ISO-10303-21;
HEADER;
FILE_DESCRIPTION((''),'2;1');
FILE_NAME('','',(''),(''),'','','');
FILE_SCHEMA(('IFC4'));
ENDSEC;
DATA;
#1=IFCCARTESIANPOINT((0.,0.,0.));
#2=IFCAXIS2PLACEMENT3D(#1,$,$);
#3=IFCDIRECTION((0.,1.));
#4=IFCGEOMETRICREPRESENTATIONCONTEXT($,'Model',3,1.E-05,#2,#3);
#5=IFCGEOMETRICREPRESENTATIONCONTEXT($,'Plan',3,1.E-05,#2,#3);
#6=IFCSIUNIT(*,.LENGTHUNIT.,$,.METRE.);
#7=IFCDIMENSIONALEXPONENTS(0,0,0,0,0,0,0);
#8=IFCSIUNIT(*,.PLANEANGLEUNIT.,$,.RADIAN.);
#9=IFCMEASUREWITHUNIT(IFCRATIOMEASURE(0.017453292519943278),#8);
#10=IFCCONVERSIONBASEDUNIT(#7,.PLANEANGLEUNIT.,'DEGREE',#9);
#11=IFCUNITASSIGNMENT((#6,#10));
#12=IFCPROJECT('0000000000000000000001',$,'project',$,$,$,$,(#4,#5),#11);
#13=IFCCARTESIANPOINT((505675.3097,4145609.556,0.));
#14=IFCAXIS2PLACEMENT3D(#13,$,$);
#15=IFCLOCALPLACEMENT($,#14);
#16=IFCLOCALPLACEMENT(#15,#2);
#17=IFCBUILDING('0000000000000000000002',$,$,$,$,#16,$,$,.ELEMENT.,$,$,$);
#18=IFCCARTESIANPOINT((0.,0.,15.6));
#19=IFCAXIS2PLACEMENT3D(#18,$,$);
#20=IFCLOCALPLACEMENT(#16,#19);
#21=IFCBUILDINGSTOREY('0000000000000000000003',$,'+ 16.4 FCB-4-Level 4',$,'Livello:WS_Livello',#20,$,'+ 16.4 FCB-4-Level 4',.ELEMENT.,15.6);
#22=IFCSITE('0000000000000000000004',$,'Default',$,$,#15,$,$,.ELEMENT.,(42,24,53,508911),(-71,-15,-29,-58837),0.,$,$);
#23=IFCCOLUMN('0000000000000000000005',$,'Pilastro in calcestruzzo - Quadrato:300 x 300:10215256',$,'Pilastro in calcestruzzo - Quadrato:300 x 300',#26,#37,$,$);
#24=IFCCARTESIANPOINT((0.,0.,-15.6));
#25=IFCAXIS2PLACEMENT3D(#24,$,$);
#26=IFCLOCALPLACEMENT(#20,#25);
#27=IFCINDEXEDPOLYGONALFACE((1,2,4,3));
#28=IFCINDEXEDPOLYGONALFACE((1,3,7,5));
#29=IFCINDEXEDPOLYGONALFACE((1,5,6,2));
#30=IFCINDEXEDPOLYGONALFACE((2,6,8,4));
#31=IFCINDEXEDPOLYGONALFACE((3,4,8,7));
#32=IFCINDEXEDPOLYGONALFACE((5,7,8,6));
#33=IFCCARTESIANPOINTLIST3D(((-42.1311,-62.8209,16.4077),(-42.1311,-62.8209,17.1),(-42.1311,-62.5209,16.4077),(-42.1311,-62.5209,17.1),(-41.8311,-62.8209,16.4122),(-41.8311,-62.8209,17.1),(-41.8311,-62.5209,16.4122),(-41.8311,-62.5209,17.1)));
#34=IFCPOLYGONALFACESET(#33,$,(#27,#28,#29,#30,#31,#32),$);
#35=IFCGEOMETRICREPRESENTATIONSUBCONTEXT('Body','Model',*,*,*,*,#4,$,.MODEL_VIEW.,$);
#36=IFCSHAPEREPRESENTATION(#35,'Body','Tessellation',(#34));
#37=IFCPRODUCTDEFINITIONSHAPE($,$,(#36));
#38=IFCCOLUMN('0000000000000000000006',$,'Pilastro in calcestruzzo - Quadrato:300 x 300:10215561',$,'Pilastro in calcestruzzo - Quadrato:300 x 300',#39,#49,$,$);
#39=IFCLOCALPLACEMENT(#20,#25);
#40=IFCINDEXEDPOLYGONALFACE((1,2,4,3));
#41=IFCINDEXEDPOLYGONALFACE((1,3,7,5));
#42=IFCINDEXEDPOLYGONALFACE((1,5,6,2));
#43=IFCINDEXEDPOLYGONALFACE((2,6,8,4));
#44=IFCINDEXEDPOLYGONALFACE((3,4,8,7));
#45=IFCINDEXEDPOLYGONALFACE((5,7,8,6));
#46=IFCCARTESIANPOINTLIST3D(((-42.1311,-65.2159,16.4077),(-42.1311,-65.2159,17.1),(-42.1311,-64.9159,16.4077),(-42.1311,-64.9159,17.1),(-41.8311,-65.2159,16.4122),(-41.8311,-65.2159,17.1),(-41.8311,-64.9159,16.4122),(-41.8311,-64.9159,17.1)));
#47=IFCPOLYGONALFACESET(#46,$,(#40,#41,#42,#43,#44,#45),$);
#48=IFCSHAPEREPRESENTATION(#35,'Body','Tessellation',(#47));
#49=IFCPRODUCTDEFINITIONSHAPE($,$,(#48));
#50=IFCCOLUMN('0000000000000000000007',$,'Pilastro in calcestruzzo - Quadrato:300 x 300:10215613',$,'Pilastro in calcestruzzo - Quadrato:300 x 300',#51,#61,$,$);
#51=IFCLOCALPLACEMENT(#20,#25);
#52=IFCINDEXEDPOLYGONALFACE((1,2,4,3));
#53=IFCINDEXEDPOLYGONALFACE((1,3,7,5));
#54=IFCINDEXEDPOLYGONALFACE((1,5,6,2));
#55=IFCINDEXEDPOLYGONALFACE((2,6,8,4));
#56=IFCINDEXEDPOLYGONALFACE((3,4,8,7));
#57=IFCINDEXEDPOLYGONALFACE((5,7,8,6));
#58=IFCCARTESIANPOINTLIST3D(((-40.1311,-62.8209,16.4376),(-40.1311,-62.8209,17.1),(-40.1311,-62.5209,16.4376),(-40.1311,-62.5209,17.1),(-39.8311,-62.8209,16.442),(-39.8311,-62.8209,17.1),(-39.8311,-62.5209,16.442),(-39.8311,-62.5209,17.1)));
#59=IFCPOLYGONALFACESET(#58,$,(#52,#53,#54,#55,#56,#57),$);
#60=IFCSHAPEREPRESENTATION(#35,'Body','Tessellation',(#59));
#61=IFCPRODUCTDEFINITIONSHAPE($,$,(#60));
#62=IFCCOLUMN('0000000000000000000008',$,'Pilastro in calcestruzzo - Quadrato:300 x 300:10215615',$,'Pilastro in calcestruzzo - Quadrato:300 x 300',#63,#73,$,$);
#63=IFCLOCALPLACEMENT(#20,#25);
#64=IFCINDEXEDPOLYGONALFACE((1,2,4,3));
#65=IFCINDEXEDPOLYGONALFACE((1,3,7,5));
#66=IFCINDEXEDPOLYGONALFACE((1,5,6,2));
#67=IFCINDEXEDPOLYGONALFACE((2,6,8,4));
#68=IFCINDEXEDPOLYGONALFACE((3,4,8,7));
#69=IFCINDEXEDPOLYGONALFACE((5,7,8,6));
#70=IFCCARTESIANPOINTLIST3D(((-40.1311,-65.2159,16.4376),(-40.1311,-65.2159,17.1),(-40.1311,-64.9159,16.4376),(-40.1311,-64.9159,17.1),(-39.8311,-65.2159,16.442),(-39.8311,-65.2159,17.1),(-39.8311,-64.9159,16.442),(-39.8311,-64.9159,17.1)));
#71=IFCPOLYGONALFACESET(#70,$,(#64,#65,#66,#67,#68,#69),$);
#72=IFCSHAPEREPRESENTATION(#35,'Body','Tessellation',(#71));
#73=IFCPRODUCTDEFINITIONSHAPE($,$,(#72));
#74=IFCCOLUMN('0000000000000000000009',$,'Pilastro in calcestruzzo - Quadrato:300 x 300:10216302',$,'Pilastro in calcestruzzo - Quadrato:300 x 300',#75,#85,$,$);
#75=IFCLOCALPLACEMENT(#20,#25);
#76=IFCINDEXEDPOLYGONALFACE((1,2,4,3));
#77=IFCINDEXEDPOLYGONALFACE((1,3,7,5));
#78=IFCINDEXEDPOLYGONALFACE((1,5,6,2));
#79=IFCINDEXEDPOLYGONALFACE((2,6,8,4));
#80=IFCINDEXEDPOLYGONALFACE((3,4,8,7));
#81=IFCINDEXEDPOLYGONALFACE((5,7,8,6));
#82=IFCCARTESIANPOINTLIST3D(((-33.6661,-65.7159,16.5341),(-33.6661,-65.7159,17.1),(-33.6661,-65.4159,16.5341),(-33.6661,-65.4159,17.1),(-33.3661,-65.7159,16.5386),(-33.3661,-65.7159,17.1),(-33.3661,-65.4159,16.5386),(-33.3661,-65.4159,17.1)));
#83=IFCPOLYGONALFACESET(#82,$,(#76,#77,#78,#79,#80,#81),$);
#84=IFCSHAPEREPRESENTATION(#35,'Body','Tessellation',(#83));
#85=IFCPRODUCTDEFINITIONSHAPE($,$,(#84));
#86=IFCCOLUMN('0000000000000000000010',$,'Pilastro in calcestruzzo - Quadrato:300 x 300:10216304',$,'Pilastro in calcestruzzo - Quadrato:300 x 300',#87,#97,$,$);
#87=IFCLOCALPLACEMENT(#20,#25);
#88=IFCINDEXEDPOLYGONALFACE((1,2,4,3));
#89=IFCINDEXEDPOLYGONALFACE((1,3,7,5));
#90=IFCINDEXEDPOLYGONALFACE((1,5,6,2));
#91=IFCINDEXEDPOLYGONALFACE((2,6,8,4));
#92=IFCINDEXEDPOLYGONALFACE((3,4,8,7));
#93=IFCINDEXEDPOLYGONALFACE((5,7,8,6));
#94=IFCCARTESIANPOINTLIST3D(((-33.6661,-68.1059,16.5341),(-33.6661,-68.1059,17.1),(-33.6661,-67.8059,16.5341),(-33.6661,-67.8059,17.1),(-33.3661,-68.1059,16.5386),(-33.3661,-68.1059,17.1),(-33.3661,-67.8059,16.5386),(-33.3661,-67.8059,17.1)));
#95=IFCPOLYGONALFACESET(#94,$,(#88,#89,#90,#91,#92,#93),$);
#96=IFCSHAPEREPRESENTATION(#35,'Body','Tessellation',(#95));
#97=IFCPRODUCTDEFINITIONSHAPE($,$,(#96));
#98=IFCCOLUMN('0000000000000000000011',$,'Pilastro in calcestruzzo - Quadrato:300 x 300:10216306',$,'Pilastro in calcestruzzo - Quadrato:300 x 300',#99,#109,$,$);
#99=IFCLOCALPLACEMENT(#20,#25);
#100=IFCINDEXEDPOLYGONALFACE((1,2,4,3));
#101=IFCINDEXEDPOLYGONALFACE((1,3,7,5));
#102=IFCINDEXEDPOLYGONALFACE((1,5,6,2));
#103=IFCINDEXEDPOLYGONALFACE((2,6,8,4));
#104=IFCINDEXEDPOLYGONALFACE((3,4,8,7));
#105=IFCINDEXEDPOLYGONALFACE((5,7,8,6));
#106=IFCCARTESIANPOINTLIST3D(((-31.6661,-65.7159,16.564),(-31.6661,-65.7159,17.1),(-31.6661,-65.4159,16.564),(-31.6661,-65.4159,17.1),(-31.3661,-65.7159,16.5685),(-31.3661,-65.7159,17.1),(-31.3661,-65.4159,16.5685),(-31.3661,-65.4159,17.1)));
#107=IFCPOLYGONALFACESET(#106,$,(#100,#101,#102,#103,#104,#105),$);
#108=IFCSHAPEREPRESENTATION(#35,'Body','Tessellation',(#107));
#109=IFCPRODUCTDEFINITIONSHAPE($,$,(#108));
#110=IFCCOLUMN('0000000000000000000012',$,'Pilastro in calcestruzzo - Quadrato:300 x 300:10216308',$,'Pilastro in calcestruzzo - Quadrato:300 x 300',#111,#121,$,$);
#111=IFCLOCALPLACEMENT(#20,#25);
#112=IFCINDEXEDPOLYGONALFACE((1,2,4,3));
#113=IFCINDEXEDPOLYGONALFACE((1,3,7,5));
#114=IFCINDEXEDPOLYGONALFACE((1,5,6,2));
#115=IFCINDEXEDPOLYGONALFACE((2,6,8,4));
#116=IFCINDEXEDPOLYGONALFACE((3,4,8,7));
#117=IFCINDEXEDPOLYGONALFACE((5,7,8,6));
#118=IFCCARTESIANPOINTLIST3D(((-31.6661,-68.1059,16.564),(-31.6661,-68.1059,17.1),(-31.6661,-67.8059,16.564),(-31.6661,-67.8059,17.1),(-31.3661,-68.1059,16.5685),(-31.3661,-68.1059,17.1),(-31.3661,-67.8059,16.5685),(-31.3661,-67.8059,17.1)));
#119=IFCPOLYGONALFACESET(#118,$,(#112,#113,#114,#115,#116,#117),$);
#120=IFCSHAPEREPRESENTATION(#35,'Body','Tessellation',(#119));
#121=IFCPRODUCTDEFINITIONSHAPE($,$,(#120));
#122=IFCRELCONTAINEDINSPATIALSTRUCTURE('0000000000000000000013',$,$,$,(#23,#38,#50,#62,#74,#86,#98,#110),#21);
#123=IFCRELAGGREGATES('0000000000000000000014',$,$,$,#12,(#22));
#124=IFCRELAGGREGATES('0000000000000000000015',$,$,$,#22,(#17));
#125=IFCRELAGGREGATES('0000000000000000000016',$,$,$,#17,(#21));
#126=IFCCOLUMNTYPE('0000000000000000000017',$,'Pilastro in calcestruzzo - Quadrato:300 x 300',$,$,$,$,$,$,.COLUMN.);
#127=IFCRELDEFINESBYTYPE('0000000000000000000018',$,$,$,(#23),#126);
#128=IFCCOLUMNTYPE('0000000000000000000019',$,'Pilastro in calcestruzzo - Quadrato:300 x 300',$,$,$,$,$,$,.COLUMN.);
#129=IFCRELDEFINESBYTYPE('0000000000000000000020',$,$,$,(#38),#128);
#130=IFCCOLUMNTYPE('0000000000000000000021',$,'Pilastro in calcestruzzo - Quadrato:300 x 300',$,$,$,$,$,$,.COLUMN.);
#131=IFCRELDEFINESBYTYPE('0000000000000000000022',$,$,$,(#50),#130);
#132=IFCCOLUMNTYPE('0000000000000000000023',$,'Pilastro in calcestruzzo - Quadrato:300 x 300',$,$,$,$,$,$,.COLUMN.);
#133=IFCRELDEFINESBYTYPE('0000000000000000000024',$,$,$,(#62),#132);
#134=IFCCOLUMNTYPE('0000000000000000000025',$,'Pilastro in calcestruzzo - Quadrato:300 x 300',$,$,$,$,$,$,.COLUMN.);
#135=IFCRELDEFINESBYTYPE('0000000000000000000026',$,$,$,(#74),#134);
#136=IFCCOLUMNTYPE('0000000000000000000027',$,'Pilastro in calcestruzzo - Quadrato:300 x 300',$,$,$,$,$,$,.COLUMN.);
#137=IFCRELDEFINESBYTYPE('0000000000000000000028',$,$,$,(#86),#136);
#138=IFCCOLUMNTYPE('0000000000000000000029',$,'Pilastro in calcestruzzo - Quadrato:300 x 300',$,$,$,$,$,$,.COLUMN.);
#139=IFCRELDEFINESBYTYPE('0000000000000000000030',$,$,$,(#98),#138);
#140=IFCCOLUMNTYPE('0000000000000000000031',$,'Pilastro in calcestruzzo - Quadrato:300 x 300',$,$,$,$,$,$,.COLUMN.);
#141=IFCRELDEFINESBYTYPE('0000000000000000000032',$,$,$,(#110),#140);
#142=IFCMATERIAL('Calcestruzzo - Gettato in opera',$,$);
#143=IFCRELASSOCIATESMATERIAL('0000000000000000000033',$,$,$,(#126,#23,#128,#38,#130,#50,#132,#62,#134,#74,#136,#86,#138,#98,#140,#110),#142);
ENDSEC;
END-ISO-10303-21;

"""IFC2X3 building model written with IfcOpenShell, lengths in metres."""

from ifc_helpers import new_model, entity, si_unit, converted_unit, direction, frame, frame_2d, origin, origin_2d_with_axis, place, context, subcontext, project, spatial, rectangle, extrude, clip, halfspace, source, transform, mapped, material, type_object, type_shapes, element, save


model = new_model("IFC2X3")

# Units and contexts
model_context = context("Model", 3, precision=1e-05, world=origin(), true_north=direction((0.0, 1.0)))
plan_context = context("Plan", 3, precision=1e-05, world=origin(), true_north=direction((0.0, 1.0)))
body_context = subcontext(model_context, "Body", "Model", "MODEL_VIEW")
ifc_project = project(units=[si_unit("LENGTHUNIT", "METRE"), converted_unit("PLANEANGLEUNIT", "DEGREE", entity("IfcRatioMeasure", 0.017453292519943278), si_unit("PLANEANGLEUNIT", "RADIAN"), dimensions=[0, 0, 0, 0, 0, 0, 0])], contexts=[model_context, plan_context])

# Site, building, storey
site_placement = place(None, frame((505675.3097, 4145609.556, 0.0)))
site = spatial("IfcSite", under=ifc_project, at=site_placement, Name="Default", CompositionType="ELEMENT", RefLatitude=(42, 24, 53, 508911), RefLongitude=(-71, -15, -29, -58837), RefElevation=0.0)
building_placement = place(site_placement, origin())
building = spatial("IfcBuilding", under=site, at=building_placement, CompositionType="ELEMENT")
storey_placement = place(building_placement, frame((0.0, 0.0, 15.6)))
storey = spatial("IfcBuildingStorey", under=building, at=storey_placement, Name="+ 16.4 FCB-4-Level 4", ObjectType="Livello:WS_Livello", LongName="+ 16.4 FCB-4-Level 4", CompositionType="ELEMENT", Elevation=15.6)

# Columns
ifc_material_1 = material(Name="Calcestruzzo - Gettato in opera")
column_type_1 = type_object("IfcColumnType", Name="Pilastro in calcestruzzo - Quadrato:300 x 300", PredefinedType="COLUMN", material=ifc_material_1)
shared_shape_1 = source(origin(), body_context, "Body", "SweptSolid", [
    clip(extrude(rectangle(XDim=0.3, YDim=0.3, at=origin_2d_with_axis()), frame((-41.9811, -62.6709, 16.4077), z_axis=(0.0, 0.0, 1.0), x_axis=(0.0, -1.0, 0.0)), (0.0, 0.0, 1.0), 0.6923), halfspace(frame((-36.6211, -74.7209, 16.49), z_axis=(0.014936, 0.0, -0.999888), x_axis=(-0.999888, 0.0, -0.014936)), False)),
])
type_shapes(column_type_1, [shared_shape_1])
column_1_placement = place(storey_placement, frame((0.0, 0.0, -15.6)))
element("IfcColumn", 1, at=column_1_placement, inside=storey, type_object=column_type_1, material=ifc_material_1, Name="Pilastro in calcestruzzo - Quadrato:300 x 300:10215256", ObjectType="Pilastro in calcestruzzo - Quadrato:300 x 300", context=body_context, shape_type="MappedRepresentation", body=[
    mapped(shared_shape_1, transform((0.0, 0.0, 0.0), scale=1.0)),
])
column_type_2 = type_object("IfcColumnType", Name="Pilastro in calcestruzzo - Quadrato:300 x 300", PredefinedType="COLUMN", material=ifc_material_1)
shared_shape_2 = source(origin(), body_context, "Body", "SweptSolid", [
    clip(extrude(rectangle(XDim=0.3, YDim=0.3, at=origin_2d_with_axis()), frame((-41.9811, -65.0659, 16.4077), z_axis=(0.0, 0.0, 1.0), x_axis=(0.0, -1.0, 0.0)), (0.0, 0.0, 1.0), 0.6923), halfspace(frame((-36.6211, -74.7209, 16.49), z_axis=(0.014936, 0.0, -0.999888), x_axis=(-0.999888, 0.0, -0.014936)), False)),
])
type_shapes(column_type_2, [shared_shape_2])
column_2_placement = place(storey_placement, frame((0.0, 0.0, -15.6)))
element("IfcColumn", 2, at=column_2_placement, inside=storey, type_object=column_type_2, material=ifc_material_1, Name="Pilastro in calcestruzzo - Quadrato:300 x 300:10215561", ObjectType="Pilastro in calcestruzzo - Quadrato:300 x 300", context=body_context, shape_type="MappedRepresentation", body=[
    mapped(shared_shape_2, transform((0.0, 0.0, 0.0), scale=1.0)),
])
column_type_3 = type_object("IfcColumnType", Name="Pilastro in calcestruzzo - Quadrato:300 x 300", PredefinedType="COLUMN", material=ifc_material_1)
shared_shape_3 = source(origin(), body_context, "Body", "SweptSolid", [
    clip(extrude(rectangle(XDim=0.3, YDim=0.3, at=frame_2d((0.0, 0.0), x_axis=(1.0, 0.0))), frame((-39.9811, -62.6709, 16.4376), z_axis=(0.0, 0.0, 1.0), x_axis=(0.0, -1.0, 0.0)), (0.0, 0.0, 1.0), 0.6624), halfspace(frame((-36.6211, -74.7209, 16.49), z_axis=(0.014936, 0.0, -0.999888), x_axis=(-0.999888, 0.0, -0.014936)), False)),
])
type_shapes(column_type_3, [shared_shape_3])
column_3_placement = place(storey_placement, frame((0.0, 0.0, -15.6)))
element("IfcColumn", 3, at=column_3_placement, inside=storey, type_object=column_type_3, material=ifc_material_1, Name="Pilastro in calcestruzzo - Quadrato:300 x 300:10215613", ObjectType="Pilastro in calcestruzzo - Quadrato:300 x 300", context=body_context, shape_type="MappedRepresentation", body=[
    mapped(shared_shape_3, transform((0.0, 0.0, 0.0), scale=1.0)),
])
column_type_4 = type_object("IfcColumnType", Name="Pilastro in calcestruzzo - Quadrato:300 x 300", PredefinedType="COLUMN", material=ifc_material_1)
shared_shape_4 = source(origin(), body_context, "Body", "SweptSolid", [
    clip(extrude(rectangle(XDim=0.3, YDim=0.3, at=frame_2d((0.0, 0.0), x_axis=(1.0, 0.0))), frame((-39.9811, -65.0659, 16.4376), z_axis=(0.0, 0.0, 1.0), x_axis=(0.0, -1.0, 0.0)), (0.0, 0.0, 1.0), 0.6624), halfspace(frame((-36.6211, -74.7209, 16.49), z_axis=(0.014936, 0.0, -0.999888), x_axis=(-0.999888, 0.0, -0.014936)), False)),
])
type_shapes(column_type_4, [shared_shape_4])
column_4_placement = place(storey_placement, frame((0.0, 0.0, -15.6)))
element("IfcColumn", 4, at=column_4_placement, inside=storey, type_object=column_type_4, material=ifc_material_1, Name="Pilastro in calcestruzzo - Quadrato:300 x 300:10215615", ObjectType="Pilastro in calcestruzzo - Quadrato:300 x 300", context=body_context, shape_type="MappedRepresentation", body=[
    mapped(shared_shape_4, transform((0.0, 0.0, 0.0), scale=1.0)),
])
column_type_5 = type_object("IfcColumnType", Name="Pilastro in calcestruzzo - Quadrato:300 x 300", PredefinedType="COLUMN", material=ifc_material_1)
shared_shape_5 = source(origin(), body_context, "Body", "SweptSolid", [
    clip(extrude(rectangle(XDim=0.3, YDim=0.3, at=origin_2d_with_axis()), frame((-33.5161, -65.5659, 16.5341), z_axis=(0.0, 0.0, 1.0), x_axis=(0.0, -1.0, 0.0)), (0.0, 0.0, 1.0), 0.5659), halfspace(frame((-36.6211, -74.7209, 16.49), z_axis=(0.014936, 0.0, -0.999888), x_axis=(-0.999888, 0.0, -0.014936)), False)),
])
type_shapes(column_type_5, [shared_shape_5])
column_5_placement = place(storey_placement, frame((0.0, 0.0, -15.6)))
element("IfcColumn", 5, at=column_5_placement, inside=storey, type_object=column_type_5, material=ifc_material_1, Name="Pilastro in calcestruzzo - Quadrato:300 x 300:10216302", ObjectType="Pilastro in calcestruzzo - Quadrato:300 x 300", context=body_context, shape_type="MappedRepresentation", body=[
    mapped(shared_shape_5, transform((0.0, 0.0, 0.0), scale=1.0)),
])
column_type_6 = type_object("IfcColumnType", Name="Pilastro in calcestruzzo - Quadrato:300 x 300", PredefinedType="COLUMN", material=ifc_material_1)
shared_shape_6 = source(origin(), body_context, "Body", "SweptSolid", [
    clip(extrude(rectangle(XDim=0.3, YDim=0.3, at=origin_2d_with_axis()), frame((-33.5161, -67.9559, 16.5341), z_axis=(0.0, 0.0, 1.0), x_axis=(0.0, -1.0, 0.0)), (0.0, 0.0, 1.0), 0.5659), halfspace(frame((-36.6211, -74.7209, 16.49), z_axis=(0.014936, 0.0, -0.999888), x_axis=(-0.999888, 0.0, -0.014936)), False)),
])
type_shapes(column_type_6, [shared_shape_6])
column_6_placement = place(storey_placement, frame((0.0, 0.0, -15.6)))
element("IfcColumn", 6, at=column_6_placement, inside=storey, type_object=column_type_6, material=ifc_material_1, Name="Pilastro in calcestruzzo - Quadrato:300 x 300:10216304", ObjectType="Pilastro in calcestruzzo - Quadrato:300 x 300", context=body_context, shape_type="MappedRepresentation", body=[
    mapped(shared_shape_6, transform((0.0, 0.0, 0.0), scale=1.0)),
])
column_type_7 = type_object("IfcColumnType", Name="Pilastro in calcestruzzo - Quadrato:300 x 300", PredefinedType="COLUMN", material=ifc_material_1)
shared_shape_7 = source(origin(), body_context, "Body", "SweptSolid", [
    clip(extrude(rectangle(XDim=0.3, YDim=0.3, at=origin_2d_with_axis()), frame((-31.5161, -65.5659, 16.564), z_axis=(0.0, 0.0, 1.0), x_axis=(0.0, -1.0, 0.0)), (0.0, 0.0, 1.0), 0.536), halfspace(frame((-36.6211, -74.7209, 16.49), z_axis=(0.014936, 0.0, -0.999888), x_axis=(-0.999888, 0.0, -0.014936)), False)),
])
type_shapes(column_type_7, [shared_shape_7])
column_7_placement = place(storey_placement, frame((0.0, 0.0, -15.6)))
element("IfcColumn", 7, at=column_7_placement, inside=storey, type_object=column_type_7, material=ifc_material_1, Name="Pilastro in calcestruzzo - Quadrato:300 x 300:10216306", ObjectType="Pilastro in calcestruzzo - Quadrato:300 x 300", context=body_context, shape_type="MappedRepresentation", body=[
    mapped(shared_shape_7, transform((0.0, 0.0, 0.0), scale=1.0)),
])
column_type_8 = type_object("IfcColumnType", Name="Pilastro in calcestruzzo - Quadrato:300 x 300", PredefinedType="COLUMN", material=ifc_material_1)
shared_shape_8 = source(origin(), body_context, "Body", "SweptSolid", [
    clip(extrude(rectangle(XDim=0.3, YDim=0.3, at=origin_2d_with_axis()), frame((-31.5161, -67.9559, 16.564), z_axis=(0.0, 0.0, 1.0), x_axis=(0.0, -1.0, 0.0)), (0.0, 0.0, 1.0), 0.536), halfspace(frame((-36.6211, -74.7209, 16.49), z_axis=(0.014936, 0.0, -0.999888), x_axis=(-0.999888, 0.0, -0.014936)), False)),
])
type_shapes(column_type_8, [shared_shape_8])
column_8_placement = place(storey_placement, frame((0.0, 0.0, -15.6)))
element("IfcColumn", 8, at=column_8_placement, inside=storey, type_object=column_type_8, material=ifc_material_1, Name="Pilastro in calcestruzzo - Quadrato:300 x 300:10216308", ObjectType="Pilastro in calcestruzzo - Quadrato:300 x 300", context=body_context, shape_type="MappedRepresentation", body=[
    mapped(shared_shape_8, transform((0.0, 0.0, 0.0), scale=1.0)),
])

save(model, "model.ifc")
